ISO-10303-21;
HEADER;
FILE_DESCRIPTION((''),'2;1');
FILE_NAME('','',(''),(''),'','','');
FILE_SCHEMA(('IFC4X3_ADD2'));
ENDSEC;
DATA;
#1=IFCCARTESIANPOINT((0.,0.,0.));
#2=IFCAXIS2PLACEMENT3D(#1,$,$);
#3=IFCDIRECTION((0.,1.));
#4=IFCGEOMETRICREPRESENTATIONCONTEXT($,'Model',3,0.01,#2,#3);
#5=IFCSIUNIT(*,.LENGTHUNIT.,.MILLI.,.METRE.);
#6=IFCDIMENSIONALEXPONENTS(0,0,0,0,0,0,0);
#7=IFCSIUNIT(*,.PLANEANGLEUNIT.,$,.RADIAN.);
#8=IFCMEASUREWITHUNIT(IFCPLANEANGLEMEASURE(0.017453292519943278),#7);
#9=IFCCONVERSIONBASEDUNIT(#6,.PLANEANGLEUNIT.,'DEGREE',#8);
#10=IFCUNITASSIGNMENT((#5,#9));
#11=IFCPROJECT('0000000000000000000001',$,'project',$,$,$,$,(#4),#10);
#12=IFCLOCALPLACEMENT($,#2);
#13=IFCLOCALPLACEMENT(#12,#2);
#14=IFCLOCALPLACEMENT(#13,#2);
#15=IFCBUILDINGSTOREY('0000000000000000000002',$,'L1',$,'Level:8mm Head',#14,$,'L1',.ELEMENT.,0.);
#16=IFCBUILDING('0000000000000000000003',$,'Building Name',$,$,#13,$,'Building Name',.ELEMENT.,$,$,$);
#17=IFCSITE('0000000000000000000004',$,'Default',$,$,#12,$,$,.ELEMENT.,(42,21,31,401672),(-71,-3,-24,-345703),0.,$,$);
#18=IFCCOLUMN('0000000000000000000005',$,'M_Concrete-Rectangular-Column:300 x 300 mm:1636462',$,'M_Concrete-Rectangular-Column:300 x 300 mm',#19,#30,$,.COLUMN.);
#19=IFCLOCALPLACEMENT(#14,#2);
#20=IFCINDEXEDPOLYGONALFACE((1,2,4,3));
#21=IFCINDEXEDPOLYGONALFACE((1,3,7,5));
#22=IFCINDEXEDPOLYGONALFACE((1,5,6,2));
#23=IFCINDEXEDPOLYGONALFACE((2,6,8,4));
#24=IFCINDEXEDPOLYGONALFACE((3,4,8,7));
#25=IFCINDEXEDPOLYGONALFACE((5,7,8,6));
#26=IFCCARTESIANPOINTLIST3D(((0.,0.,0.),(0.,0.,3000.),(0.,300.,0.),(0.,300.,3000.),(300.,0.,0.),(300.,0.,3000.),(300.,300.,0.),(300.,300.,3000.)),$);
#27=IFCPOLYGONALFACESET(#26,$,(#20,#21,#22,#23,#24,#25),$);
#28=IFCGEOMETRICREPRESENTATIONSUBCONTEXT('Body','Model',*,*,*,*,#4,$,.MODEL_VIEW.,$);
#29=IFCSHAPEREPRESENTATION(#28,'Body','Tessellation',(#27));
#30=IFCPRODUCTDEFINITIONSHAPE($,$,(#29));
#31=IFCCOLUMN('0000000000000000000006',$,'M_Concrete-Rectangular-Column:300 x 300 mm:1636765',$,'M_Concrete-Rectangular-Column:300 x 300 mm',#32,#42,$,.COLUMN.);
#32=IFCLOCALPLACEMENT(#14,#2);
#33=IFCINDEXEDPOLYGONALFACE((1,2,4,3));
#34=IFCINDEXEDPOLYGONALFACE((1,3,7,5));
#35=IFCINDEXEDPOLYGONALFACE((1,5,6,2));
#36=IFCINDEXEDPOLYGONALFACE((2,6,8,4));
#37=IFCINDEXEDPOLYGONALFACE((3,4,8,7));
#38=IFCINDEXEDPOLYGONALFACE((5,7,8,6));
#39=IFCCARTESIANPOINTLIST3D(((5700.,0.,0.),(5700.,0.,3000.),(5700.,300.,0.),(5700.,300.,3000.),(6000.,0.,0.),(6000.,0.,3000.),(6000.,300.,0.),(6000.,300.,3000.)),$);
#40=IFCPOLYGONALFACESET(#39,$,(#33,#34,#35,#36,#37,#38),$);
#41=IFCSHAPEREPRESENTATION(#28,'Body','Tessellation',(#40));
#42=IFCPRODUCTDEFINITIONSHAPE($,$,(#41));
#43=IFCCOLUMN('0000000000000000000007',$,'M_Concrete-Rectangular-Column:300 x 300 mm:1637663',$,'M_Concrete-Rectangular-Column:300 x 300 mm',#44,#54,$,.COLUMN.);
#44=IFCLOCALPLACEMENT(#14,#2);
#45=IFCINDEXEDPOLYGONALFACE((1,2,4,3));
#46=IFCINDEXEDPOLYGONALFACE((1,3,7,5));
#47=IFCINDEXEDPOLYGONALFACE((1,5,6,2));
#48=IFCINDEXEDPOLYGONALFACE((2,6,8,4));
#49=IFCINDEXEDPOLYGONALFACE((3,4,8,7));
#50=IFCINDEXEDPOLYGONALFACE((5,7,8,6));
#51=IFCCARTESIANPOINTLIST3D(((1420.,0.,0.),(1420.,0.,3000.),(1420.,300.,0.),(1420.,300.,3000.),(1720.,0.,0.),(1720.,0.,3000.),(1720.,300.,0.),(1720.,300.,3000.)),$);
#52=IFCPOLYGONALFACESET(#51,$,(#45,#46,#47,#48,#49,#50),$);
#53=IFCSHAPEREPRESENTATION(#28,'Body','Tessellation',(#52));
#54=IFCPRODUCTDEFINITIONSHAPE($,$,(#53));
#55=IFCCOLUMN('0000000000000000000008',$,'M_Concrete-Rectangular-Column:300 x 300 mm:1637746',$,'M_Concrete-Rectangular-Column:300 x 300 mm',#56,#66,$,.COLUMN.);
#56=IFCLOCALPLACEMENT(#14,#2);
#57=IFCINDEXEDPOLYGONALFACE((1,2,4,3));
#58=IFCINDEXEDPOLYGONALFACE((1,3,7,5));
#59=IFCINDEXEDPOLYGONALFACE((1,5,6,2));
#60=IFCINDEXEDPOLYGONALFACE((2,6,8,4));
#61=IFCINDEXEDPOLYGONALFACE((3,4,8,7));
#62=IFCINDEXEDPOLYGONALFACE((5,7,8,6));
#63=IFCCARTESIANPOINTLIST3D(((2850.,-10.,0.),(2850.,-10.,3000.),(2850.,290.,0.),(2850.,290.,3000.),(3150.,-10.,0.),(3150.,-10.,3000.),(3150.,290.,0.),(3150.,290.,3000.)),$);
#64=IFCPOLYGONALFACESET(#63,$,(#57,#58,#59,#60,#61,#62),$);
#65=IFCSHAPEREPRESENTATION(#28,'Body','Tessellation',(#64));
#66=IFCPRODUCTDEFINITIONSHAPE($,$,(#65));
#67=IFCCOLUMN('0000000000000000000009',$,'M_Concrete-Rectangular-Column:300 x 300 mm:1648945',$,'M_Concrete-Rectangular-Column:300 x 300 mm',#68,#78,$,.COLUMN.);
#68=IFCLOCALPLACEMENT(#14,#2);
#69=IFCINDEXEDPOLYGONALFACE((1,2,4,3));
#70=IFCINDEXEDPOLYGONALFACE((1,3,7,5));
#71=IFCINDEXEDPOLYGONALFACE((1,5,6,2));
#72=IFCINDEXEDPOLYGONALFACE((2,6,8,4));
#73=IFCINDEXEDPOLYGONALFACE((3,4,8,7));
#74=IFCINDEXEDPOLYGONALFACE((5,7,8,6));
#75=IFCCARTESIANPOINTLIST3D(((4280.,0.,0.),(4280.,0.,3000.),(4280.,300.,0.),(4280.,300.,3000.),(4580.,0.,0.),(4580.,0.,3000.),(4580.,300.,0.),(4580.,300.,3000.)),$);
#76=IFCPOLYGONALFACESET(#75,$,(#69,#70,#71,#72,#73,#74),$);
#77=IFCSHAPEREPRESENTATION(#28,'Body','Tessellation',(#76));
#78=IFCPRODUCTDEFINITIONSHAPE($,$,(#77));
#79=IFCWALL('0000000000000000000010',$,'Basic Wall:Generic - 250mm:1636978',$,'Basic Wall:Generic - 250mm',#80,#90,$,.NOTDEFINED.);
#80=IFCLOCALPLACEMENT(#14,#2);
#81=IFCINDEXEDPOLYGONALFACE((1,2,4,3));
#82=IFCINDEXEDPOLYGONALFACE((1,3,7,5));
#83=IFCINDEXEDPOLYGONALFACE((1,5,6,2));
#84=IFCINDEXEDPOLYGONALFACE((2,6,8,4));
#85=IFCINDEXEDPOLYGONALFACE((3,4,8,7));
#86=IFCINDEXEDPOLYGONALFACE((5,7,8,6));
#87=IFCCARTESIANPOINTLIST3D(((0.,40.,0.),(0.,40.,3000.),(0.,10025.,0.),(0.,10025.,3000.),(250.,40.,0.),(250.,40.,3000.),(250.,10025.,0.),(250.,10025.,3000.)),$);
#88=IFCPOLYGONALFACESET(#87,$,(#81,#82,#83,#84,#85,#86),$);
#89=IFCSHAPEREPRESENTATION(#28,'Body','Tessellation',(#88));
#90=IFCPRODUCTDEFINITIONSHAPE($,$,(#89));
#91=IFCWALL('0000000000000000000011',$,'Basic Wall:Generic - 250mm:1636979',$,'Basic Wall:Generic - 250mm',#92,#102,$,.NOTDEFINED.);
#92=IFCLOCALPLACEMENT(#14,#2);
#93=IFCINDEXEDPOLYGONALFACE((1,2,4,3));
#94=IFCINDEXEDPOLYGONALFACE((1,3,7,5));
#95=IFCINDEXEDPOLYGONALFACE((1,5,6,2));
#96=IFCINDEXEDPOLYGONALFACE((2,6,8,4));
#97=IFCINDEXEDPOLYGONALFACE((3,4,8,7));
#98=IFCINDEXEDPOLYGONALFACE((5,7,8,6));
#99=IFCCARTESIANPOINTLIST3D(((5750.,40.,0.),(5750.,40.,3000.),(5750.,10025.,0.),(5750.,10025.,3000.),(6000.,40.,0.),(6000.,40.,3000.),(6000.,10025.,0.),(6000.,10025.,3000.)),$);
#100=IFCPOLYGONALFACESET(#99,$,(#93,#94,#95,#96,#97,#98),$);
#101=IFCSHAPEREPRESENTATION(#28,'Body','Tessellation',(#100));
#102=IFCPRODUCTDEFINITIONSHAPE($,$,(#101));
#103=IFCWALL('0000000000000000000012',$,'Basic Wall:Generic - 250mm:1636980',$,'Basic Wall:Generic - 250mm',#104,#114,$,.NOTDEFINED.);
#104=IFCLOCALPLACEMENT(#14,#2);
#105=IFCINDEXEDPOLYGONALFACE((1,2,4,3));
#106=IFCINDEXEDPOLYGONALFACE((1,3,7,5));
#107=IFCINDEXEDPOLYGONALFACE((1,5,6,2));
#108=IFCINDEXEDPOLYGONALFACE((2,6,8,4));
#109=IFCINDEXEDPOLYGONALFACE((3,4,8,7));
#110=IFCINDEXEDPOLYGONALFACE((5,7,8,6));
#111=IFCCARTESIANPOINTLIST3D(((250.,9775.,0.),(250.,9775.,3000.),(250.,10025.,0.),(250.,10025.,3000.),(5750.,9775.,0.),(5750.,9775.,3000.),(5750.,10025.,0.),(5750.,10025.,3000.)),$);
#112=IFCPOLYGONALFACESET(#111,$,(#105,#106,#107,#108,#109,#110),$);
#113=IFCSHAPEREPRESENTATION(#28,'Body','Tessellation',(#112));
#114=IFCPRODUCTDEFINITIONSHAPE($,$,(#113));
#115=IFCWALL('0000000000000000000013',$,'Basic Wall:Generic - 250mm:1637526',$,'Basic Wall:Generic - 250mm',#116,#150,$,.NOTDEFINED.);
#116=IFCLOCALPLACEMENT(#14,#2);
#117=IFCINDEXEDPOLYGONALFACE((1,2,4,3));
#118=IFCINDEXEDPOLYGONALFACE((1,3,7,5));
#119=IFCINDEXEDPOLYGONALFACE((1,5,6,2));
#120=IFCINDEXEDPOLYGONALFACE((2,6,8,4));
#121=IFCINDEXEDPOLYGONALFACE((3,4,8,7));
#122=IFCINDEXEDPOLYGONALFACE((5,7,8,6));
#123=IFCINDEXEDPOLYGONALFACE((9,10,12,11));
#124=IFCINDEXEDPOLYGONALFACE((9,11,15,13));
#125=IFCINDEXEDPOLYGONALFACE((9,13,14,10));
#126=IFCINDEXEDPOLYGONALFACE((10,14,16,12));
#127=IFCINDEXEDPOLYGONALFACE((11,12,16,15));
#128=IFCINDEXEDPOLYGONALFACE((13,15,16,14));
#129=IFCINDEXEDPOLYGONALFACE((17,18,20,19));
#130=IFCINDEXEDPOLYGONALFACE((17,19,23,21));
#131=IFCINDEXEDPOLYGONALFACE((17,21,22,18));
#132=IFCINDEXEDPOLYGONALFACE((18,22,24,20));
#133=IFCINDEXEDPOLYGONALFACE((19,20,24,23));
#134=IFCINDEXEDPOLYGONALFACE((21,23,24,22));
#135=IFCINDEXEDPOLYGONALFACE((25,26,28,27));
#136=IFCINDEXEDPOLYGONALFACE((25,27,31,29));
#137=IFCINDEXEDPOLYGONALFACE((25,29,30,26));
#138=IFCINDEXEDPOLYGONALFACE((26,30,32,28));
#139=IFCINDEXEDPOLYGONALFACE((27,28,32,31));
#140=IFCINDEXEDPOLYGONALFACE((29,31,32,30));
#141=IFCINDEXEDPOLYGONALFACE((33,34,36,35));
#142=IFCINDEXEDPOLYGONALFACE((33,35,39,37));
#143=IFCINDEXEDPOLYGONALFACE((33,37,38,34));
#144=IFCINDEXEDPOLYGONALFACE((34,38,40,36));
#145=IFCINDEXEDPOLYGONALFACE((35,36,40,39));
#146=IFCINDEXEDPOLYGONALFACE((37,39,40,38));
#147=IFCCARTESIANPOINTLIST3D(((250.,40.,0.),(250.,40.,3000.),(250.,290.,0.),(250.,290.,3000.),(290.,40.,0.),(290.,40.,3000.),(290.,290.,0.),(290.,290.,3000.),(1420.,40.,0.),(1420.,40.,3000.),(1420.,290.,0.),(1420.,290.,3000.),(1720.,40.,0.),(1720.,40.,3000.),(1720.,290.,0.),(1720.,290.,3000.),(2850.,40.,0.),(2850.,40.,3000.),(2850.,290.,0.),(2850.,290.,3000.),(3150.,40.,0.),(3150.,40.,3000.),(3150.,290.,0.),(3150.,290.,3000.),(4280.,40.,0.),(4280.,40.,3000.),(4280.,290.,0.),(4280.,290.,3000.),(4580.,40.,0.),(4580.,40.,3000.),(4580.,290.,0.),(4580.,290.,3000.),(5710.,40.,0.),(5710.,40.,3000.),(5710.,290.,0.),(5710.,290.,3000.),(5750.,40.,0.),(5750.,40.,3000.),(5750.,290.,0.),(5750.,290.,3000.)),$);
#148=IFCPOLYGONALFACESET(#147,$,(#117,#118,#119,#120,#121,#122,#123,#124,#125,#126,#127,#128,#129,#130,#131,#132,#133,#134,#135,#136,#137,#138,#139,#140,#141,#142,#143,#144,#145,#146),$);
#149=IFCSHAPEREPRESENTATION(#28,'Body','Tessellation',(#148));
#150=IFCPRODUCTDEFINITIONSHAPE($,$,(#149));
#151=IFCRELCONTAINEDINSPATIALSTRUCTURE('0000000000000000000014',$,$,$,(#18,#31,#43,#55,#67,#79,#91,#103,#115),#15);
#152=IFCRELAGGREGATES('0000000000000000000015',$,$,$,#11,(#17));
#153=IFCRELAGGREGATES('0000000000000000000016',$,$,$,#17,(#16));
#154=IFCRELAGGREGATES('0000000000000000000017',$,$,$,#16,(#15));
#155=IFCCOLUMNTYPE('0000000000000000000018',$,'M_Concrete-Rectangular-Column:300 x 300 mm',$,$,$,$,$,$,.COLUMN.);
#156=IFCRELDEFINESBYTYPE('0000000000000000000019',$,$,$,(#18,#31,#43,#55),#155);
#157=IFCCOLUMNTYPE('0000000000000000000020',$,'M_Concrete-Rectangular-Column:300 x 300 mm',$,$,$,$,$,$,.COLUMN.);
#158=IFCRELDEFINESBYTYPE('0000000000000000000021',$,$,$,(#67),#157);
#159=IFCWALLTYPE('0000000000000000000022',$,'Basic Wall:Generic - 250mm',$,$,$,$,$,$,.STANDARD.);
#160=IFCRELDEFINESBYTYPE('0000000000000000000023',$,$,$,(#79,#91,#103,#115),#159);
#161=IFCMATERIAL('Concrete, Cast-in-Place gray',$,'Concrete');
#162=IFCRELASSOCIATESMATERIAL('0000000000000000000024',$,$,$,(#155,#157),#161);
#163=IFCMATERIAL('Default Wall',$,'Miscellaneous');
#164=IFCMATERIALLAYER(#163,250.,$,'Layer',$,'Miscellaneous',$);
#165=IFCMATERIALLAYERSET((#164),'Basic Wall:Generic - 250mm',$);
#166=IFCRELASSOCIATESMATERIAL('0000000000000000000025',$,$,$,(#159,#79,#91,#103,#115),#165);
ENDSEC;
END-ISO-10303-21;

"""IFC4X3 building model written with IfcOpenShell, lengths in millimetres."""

from ifc_helpers import new_model, entity, si_unit, converted_unit, direction, frame, frame_2d, origin, origin_2d_with_axis, place, context, subcontext, project, spatial, rectangle, extrude, source, transform, mapped, material, layer, layer_set, material_profile, profile_set, type_object, type_shapes, element, save


model = new_model("IFC4X3")

# Units and contexts
model_context = context("Model", 3, precision=0.01, world=origin(), true_north=direction((0.0, 1.0)))
body_context = subcontext(model_context, "Body", "Model", "MODEL_VIEW")
ifc_project = project(units=[si_unit("LENGTHUNIT", "METRE", prefix="MILLI"), converted_unit("PLANEANGLEUNIT", "DEGREE", entity("IfcPlaneAngleMeasure", 0.017453292519943278), si_unit("PLANEANGLEUNIT", "RADIAN"), dimensions=[0, 0, 0, 0, 0, 0, 0])], contexts=[model_context])

# Site, building, storey
site_placement = place(None, origin())
site = spatial("IfcSite", under=ifc_project, at=site_placement, Name="Default", CompositionType="ELEMENT", RefLatitude=(42, 21, 31, 401672), RefLongitude=(-71, -3, -24, -345703), RefElevation=0.0)
building_placement = place(site_placement, origin())
building = spatial("IfcBuilding", under=site, at=building_placement, Name="Building Name", LongName="Building Name", CompositionType="ELEMENT")
storey_placement = place(building_placement, origin())
storey = spatial("IfcBuildingStorey", under=building, at=storey_placement, Name="L1", ObjectType="Level:8mm Head", LongName="L1", CompositionType="ELEMENT", Elevation=0.0)

# Columns
ifc_material_1 = material(Name="Concrete, Cast-in-Place gray", Category="Concrete")
ifc_material_profile = material_profile(ifc_material_1, rectangle(XDim=300.0, YDim=300.0, at=origin_2d_with_axis()), Name="300 x 300 mm")
ifc_profile_set = profile_set([ifc_material_profile], Name="300 x 300 mm")
column_type_1 = type_object("IfcColumnType", Name="M_Concrete-Rectangular-Column:300 x 300 mm", PredefinedType="COLUMN", material=ifc_profile_set)
shared_shape_1 = source(origin(), body_context, "Body", "SweptSolid", [
    extrude(rectangle(XDim=300.0, YDim=300.0, at=origin_2d_with_axis()), frame((0.0, 0.0, 0.0), z_axis=(0.0, 0.0, 1.0), x_axis=(-1.0, 0.0, 0.0)), (0.0, 0.0, 1.0), 3000.0),
])
type_shapes(column_type_1, [shared_shape_1])
for number, where, name in (
    (1, (150.0, 150.0, 0.0), "M_Concrete-Rectangular-Column:300 x 300 mm:1636462"),
    (2, (5850.0, 150.0, 0.0), "M_Concrete-Rectangular-Column:300 x 300 mm:1636765"),
    (3, (1570.0, 150.0, 0.0), "M_Concrete-Rectangular-Column:300 x 300 mm:1637663"),
    (4, (3000.0, 140.0, 0.0), "M_Concrete-Rectangular-Column:300 x 300 mm:1637746"),
):
    element("IfcColumn", number, at=place(storey_placement, frame(where)), inside=storey, type_object=column_type_1, Name=name, ObjectType="M_Concrete-Rectangular-Column:300 x 300 mm", PredefinedType="COLUMN", context=body_context, shape_type="MappedRepresentation", body=[
        mapped(shared_shape_1, transform((0.0, 0.0, 0.0), scale=1.0)),
    ])
column_type_2 = type_object("IfcColumnType", Name="M_Concrete-Rectangular-Column:300 x 300 mm", PredefinedType="COLUMN", material=ifc_profile_set)
shared_shape_2 = source(origin(), body_context, "Body", "SweptSolid", [
    extrude(rectangle(XDim=300.0, YDim=300.0, at=origin_2d_with_axis()), frame((0.0, 0.0, 0.0), z_axis=(0.0, 0.0, 1.0), x_axis=(0.0, 1.0, 0.0)), (0.0, 0.0, 1.0), 3000.0),
])
type_shapes(column_type_2, [shared_shape_2])
column_placement = place(storey_placement, frame((4430.0, 150.0, 0.0), z_axis=(0.0, 0.0, 1.0), x_axis=(-1.0, 0.0, 0.0)))
element("IfcColumn", 5, at=column_placement, inside=storey, type_object=column_type_2, Name="M_Concrete-Rectangular-Column:300 x 300 mm:1648945", ObjectType="M_Concrete-Rectangular-Column:300 x 300 mm", PredefinedType="COLUMN", context=body_context, shape_type="MappedRepresentation", body=[
    mapped(shared_shape_2, transform((0.0, 0.0, 0.0), scale=1.0)),
])

# Walls
ifc_material_2 = material(Name="Default Wall", Category="Miscellaneous")
ifc_layer = layer(ifc_material_2, 250.0, Name="Layer", Category="Miscellaneous")
ifc_layer_set = layer_set([ifc_layer], Name="Basic Wall:Generic - 250mm")
wall_type = type_object("IfcWallType", Name="Basic Wall:Generic - 250mm", PredefinedType="STANDARD", material=ifc_layer_set)
wall_1_placement = place(storey_placement, frame((125.0, 10025.0, 0.0), z_axis=(0.0, 0.0, 1.0), x_axis=(0.0, -1.0, 0.0)))
element("IfcWall", 6, at=wall_1_placement, inside=storey, type_object=wall_type, material=ifc_layer_set, Name="Basic Wall:Generic - 250mm:1636978", ObjectType="Basic Wall:Generic - 250mm", PredefinedType="NOTDEFINED", context=body_context, shape_type="SweptSolid", body=[
    extrude(rectangle(XDim=9985.0, YDim=250.0, at=frame_2d((4992.5, 0.0), x_axis=(-1.0, 0.0))), origin(), (0.0, 0.0, 1.0), 3000.0),
])
wall_2_placement = place(storey_placement, frame((5875.0, 40.0, 0.0), z_axis=(0.0, 0.0, 1.0), x_axis=(0.0, 1.0, 0.0)))
element("IfcWall", 7, at=wall_2_placement, inside=storey, type_object=wall_type, material=ifc_layer_set, Name="Basic Wall:Generic - 250mm:1636979", ObjectType="Basic Wall:Generic - 250mm", PredefinedType="NOTDEFINED", context=body_context, shape_type="SweptSolid", body=[
    extrude(rectangle(XDim=9985.0, YDim=250.0, at=frame_2d((4992.5, 0.0), x_axis=(-1.0, 0.0))), origin(), (0.0, 0.0, 1.0), 3000.0),
])
wall_3_placement = place(storey_placement, frame((5750.0, 9900.0, 0.0), z_axis=(0.0, 0.0, 1.0), x_axis=(-1.0, 0.0, 0.0)))
element("IfcWall", 8, at=wall_3_placement, inside=storey, type_object=wall_type, material=ifc_layer_set, Name="Basic Wall:Generic - 250mm:1636980", ObjectType="Basic Wall:Generic - 250mm", PredefinedType="NOTDEFINED", context=body_context, shape_type="SweptSolid", body=[
    extrude(rectangle(XDim=5500.0, YDim=250.0, at=frame_2d((2750.0, 0.0), x_axis=(-1.0, 0.0))), origin(), (0.0, 0.0, 1.0), 3000.0),
])

# Wall, openings
wall_4_placement = place(storey_placement, frame((250.0, 165.0, 0.0)))
wall_4 = element("IfcWall", 9, at=wall_4_placement, inside=storey, type_object=wall_type, material=ifc_layer_set, Name="Basic Wall:Generic - 250mm:1637526", ObjectType="Basic Wall:Generic - 250mm", PredefinedType="NOTDEFINED", context=body_context, shape_type="SweptSolid", body=[
    extrude(rectangle(XDim=5500.0, YDim=250.0, at=frame_2d((2750.0, 0.0), x_axis=(-1.0, 0.0))), origin(), (0.0, 0.0, 1.0), 3000.0),
])
opening_1_placement = place(wall_4_placement, frame((40.0, -125.0, 0.0)))
element("IfcOpeningElement", 10, at=opening_1_placement, cuts=wall_4, PredefinedType="OPENING", context=body_context, shape_type="SweptSolid", body=[
    extrude(rectangle(XDim=3000.0, YDim=1130.0, at=frame_2d((1500.0, 565.0), x_axis=(-1.0, 0.0))), frame((0.0, 0.0, 0.0), z_axis=(0.0, 1.0, 0.0), x_axis=(0.0, 0.0, 1.0)), (0.0, 0.0, 1.0), 250.0),
])
opening_2_placement = place(wall_4_placement, frame((1470.0, -125.0, 0.0)))
element("IfcOpeningElement", 11, at=opening_2_placement, cuts=wall_4, PredefinedType="OPENING", context=body_context, shape_type="SweptSolid", body=[
    extrude(rectangle(XDim=3000.0, YDim=1130.0, at=frame_2d((1500.0, 565.0), x_axis=(-1.0, 0.0))), frame((0.0, 0.0, 0.0), z_axis=(0.0, 1.0, 0.0), x_axis=(0.0, 0.0, 1.0)), (0.0, 0.0, 1.0), 250.0),
])
opening_3_placement = place(wall_4_placement, frame((4330.0, -125.0, 0.0)))
element("IfcOpeningElement", 12, at=opening_3_placement, cuts=wall_4, PredefinedType="OPENING", context=body_context, shape_type="SweptSolid", body=[
    extrude(rectangle(XDim=3000.0, YDim=1130.0, at=frame_2d((1500.0, 565.0), x_axis=(-1.0, 0.0))), frame((0.0, 0.0, 0.0), z_axis=(0.0, 1.0, 0.0), x_axis=(0.0, 0.0, 1.0)), (0.0, 0.0, 1.0), 250.0),
])
opening_4_placement = place(wall_4_placement, frame((2900.0, -125.0, 0.0)))
element("IfcOpeningElement", 13, at=opening_4_placement, cuts=wall_4, PredefinedType="OPENING", context=body_context, shape_type="SweptSolid", body=[
    extrude(rectangle(XDim=3000.0, YDim=1130.0, at=frame_2d((1500.0, 565.0), x_axis=(-1.0, 0.0))), frame((0.0, 0.0, 0.0), z_axis=(0.0, 1.0, 0.0), x_axis=(0.0, 0.0, 1.0)), (0.0, 0.0, 1.0), 250.0),
])

save(model, "model.ifc")
